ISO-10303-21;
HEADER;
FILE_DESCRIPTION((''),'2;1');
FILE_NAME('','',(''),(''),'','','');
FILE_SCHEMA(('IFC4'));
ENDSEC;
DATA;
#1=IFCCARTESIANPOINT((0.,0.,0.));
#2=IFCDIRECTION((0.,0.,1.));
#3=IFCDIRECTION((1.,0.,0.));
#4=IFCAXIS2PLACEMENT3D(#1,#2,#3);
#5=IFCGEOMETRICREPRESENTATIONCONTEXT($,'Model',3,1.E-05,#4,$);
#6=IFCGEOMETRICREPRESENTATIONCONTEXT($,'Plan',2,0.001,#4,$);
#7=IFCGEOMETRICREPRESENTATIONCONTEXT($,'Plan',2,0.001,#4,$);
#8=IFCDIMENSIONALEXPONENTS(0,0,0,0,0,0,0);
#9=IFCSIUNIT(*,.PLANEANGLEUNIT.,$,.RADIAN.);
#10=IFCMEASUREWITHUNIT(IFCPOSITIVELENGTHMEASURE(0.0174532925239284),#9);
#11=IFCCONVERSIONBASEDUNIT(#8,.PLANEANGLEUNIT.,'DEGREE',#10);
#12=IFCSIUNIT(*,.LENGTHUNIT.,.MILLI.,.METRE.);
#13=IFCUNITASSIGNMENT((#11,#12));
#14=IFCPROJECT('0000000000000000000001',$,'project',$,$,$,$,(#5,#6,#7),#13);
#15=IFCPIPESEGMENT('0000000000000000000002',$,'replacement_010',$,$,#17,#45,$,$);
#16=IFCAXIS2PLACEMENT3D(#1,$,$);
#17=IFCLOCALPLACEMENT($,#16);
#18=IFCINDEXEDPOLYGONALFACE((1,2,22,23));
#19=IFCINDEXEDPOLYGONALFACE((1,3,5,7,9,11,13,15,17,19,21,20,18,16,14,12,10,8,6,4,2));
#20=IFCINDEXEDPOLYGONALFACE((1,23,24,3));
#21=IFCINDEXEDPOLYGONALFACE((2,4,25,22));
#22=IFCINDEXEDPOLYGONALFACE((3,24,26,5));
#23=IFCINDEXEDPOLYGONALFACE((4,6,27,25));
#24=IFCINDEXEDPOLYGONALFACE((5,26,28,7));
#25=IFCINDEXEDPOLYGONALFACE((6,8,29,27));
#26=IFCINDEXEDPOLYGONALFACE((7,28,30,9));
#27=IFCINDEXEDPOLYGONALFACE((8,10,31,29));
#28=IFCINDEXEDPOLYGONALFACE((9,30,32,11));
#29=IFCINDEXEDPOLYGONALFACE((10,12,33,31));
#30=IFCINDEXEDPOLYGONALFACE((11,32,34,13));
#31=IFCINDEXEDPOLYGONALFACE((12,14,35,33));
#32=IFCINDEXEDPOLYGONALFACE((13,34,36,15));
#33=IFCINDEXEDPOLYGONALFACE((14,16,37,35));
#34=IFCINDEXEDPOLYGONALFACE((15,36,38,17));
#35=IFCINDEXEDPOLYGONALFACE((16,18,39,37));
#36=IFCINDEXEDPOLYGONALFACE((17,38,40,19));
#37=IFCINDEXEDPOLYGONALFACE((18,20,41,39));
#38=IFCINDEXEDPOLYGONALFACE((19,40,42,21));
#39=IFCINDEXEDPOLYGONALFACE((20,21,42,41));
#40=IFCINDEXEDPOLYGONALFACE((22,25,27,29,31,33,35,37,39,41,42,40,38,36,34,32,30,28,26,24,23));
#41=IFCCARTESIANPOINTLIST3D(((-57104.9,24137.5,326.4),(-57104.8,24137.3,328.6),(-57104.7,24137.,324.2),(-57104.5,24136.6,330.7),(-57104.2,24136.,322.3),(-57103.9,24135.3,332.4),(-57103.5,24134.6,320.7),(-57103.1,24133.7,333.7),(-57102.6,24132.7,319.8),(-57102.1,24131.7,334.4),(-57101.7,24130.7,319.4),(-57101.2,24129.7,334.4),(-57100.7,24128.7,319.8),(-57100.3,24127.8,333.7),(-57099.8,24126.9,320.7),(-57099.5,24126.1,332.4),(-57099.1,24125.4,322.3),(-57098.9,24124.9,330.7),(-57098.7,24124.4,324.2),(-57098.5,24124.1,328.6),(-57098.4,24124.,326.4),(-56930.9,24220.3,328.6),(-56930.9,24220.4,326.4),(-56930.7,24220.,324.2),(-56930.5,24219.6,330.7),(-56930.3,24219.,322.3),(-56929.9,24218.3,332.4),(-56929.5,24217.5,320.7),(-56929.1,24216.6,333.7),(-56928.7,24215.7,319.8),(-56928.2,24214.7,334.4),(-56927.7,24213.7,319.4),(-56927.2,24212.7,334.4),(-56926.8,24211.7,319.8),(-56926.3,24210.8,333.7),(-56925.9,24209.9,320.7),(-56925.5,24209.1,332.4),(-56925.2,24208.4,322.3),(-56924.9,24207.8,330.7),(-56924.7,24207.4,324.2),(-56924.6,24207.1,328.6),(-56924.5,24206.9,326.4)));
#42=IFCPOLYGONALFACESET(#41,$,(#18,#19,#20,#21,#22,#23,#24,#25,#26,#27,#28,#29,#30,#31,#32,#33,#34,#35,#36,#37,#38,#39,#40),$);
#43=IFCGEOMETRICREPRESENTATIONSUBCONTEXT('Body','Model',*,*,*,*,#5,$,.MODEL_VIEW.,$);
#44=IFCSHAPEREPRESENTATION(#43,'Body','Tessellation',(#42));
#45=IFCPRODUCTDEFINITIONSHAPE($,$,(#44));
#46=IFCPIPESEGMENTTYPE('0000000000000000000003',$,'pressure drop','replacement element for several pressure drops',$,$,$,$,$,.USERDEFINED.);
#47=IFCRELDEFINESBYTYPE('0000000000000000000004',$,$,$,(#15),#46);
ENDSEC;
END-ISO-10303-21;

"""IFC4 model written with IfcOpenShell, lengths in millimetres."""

from ifc_helpers import new_model, entity, si_unit, converted_unit, frame, frame_2d, origin, origin_with_axes, place, context, subcontext, project, circle, extrude, source, transform, mapped, type_object, element, save


model = new_model("IFC4")

# Units and contexts
model_context = context("Model", 3, precision=1e-05, world=origin_with_axes())
plan_context_1 = context("Plan", 2, precision=0.001, world=origin_with_axes())
plan_context_2 = context("Plan", 2, precision=0.001, world=origin_with_axes())
body_context = subcontext(model_context, "Body", "Model", "MODEL_VIEW")
ifc_project = project(units=[converted_unit("PLANEANGLEUNIT", "DEGREE", entity("IfcPositiveLengthMeasure", 0.0174532925239284), si_unit("PLANEANGLEUNIT", "RADIAN"), dimensions=[0, 0, 0, 0, 0, 0, 0]), si_unit("LENGTHUNIT", "METRE", prefix="MILLI")], contexts=[model_context, plan_context_1, plan_context_2])

# Pipe segment
shared_shape = source(origin(), body_context, "Body", "SweptSolid", [
    extrude(circle(Radius=7.5, at=frame_2d((7.5, 7.5), x_axis=(1.0, 0.0))), frame((0.0, -7.5, -7.5), z_axis=(1.0, 0.0, 0.0), x_axis=(0.0, 1.0, 0.0)), (0.0, 0.0, 1.0), 1.0),
])
placement_1 = place(None, origin_with_axes())
placement_2 = place(placement_1, origin_with_axes())
placement_3 = place(placement_2, frame((0.0, 0.0, -3400.0), z_axis=(0.0, 0.0, 1.0), x_axis=(1.0, 0.0, 0.0)))
pipe_segment_type_1 = type_object("IfcPipeSegmentType", Name="pressure drop", Description="replacement element for several pressure drops", PredefinedType="USERDEFINED")
pipe_segment_1_placement = place(placement_3, frame((-57101.7, 24130.7, 3726.9), z_axis=(-0.430461, 0.902609, 0.0), x_axis=(0.902609, 0.430461, 0.0)))
element("IfcPipeSegment", 1, at=pipe_segment_1_placement, type_object=pipe_segment_type_1, Name="replacement_010", context=body_context, shape_type="MappedRepresentation", body=[
    mapped(shared_shape, transform((0.0, 0.0, 0.0), x_axis=(1.0, 0.0, 0.0), y_axis=(0.0, 1.0, 0.0), z_axis=(0.0, 0.0, 1.0), scale=192.697716, scale2=1.0, scale3=1.0, uniform=False)),
])

save(model, "model.ifc")
